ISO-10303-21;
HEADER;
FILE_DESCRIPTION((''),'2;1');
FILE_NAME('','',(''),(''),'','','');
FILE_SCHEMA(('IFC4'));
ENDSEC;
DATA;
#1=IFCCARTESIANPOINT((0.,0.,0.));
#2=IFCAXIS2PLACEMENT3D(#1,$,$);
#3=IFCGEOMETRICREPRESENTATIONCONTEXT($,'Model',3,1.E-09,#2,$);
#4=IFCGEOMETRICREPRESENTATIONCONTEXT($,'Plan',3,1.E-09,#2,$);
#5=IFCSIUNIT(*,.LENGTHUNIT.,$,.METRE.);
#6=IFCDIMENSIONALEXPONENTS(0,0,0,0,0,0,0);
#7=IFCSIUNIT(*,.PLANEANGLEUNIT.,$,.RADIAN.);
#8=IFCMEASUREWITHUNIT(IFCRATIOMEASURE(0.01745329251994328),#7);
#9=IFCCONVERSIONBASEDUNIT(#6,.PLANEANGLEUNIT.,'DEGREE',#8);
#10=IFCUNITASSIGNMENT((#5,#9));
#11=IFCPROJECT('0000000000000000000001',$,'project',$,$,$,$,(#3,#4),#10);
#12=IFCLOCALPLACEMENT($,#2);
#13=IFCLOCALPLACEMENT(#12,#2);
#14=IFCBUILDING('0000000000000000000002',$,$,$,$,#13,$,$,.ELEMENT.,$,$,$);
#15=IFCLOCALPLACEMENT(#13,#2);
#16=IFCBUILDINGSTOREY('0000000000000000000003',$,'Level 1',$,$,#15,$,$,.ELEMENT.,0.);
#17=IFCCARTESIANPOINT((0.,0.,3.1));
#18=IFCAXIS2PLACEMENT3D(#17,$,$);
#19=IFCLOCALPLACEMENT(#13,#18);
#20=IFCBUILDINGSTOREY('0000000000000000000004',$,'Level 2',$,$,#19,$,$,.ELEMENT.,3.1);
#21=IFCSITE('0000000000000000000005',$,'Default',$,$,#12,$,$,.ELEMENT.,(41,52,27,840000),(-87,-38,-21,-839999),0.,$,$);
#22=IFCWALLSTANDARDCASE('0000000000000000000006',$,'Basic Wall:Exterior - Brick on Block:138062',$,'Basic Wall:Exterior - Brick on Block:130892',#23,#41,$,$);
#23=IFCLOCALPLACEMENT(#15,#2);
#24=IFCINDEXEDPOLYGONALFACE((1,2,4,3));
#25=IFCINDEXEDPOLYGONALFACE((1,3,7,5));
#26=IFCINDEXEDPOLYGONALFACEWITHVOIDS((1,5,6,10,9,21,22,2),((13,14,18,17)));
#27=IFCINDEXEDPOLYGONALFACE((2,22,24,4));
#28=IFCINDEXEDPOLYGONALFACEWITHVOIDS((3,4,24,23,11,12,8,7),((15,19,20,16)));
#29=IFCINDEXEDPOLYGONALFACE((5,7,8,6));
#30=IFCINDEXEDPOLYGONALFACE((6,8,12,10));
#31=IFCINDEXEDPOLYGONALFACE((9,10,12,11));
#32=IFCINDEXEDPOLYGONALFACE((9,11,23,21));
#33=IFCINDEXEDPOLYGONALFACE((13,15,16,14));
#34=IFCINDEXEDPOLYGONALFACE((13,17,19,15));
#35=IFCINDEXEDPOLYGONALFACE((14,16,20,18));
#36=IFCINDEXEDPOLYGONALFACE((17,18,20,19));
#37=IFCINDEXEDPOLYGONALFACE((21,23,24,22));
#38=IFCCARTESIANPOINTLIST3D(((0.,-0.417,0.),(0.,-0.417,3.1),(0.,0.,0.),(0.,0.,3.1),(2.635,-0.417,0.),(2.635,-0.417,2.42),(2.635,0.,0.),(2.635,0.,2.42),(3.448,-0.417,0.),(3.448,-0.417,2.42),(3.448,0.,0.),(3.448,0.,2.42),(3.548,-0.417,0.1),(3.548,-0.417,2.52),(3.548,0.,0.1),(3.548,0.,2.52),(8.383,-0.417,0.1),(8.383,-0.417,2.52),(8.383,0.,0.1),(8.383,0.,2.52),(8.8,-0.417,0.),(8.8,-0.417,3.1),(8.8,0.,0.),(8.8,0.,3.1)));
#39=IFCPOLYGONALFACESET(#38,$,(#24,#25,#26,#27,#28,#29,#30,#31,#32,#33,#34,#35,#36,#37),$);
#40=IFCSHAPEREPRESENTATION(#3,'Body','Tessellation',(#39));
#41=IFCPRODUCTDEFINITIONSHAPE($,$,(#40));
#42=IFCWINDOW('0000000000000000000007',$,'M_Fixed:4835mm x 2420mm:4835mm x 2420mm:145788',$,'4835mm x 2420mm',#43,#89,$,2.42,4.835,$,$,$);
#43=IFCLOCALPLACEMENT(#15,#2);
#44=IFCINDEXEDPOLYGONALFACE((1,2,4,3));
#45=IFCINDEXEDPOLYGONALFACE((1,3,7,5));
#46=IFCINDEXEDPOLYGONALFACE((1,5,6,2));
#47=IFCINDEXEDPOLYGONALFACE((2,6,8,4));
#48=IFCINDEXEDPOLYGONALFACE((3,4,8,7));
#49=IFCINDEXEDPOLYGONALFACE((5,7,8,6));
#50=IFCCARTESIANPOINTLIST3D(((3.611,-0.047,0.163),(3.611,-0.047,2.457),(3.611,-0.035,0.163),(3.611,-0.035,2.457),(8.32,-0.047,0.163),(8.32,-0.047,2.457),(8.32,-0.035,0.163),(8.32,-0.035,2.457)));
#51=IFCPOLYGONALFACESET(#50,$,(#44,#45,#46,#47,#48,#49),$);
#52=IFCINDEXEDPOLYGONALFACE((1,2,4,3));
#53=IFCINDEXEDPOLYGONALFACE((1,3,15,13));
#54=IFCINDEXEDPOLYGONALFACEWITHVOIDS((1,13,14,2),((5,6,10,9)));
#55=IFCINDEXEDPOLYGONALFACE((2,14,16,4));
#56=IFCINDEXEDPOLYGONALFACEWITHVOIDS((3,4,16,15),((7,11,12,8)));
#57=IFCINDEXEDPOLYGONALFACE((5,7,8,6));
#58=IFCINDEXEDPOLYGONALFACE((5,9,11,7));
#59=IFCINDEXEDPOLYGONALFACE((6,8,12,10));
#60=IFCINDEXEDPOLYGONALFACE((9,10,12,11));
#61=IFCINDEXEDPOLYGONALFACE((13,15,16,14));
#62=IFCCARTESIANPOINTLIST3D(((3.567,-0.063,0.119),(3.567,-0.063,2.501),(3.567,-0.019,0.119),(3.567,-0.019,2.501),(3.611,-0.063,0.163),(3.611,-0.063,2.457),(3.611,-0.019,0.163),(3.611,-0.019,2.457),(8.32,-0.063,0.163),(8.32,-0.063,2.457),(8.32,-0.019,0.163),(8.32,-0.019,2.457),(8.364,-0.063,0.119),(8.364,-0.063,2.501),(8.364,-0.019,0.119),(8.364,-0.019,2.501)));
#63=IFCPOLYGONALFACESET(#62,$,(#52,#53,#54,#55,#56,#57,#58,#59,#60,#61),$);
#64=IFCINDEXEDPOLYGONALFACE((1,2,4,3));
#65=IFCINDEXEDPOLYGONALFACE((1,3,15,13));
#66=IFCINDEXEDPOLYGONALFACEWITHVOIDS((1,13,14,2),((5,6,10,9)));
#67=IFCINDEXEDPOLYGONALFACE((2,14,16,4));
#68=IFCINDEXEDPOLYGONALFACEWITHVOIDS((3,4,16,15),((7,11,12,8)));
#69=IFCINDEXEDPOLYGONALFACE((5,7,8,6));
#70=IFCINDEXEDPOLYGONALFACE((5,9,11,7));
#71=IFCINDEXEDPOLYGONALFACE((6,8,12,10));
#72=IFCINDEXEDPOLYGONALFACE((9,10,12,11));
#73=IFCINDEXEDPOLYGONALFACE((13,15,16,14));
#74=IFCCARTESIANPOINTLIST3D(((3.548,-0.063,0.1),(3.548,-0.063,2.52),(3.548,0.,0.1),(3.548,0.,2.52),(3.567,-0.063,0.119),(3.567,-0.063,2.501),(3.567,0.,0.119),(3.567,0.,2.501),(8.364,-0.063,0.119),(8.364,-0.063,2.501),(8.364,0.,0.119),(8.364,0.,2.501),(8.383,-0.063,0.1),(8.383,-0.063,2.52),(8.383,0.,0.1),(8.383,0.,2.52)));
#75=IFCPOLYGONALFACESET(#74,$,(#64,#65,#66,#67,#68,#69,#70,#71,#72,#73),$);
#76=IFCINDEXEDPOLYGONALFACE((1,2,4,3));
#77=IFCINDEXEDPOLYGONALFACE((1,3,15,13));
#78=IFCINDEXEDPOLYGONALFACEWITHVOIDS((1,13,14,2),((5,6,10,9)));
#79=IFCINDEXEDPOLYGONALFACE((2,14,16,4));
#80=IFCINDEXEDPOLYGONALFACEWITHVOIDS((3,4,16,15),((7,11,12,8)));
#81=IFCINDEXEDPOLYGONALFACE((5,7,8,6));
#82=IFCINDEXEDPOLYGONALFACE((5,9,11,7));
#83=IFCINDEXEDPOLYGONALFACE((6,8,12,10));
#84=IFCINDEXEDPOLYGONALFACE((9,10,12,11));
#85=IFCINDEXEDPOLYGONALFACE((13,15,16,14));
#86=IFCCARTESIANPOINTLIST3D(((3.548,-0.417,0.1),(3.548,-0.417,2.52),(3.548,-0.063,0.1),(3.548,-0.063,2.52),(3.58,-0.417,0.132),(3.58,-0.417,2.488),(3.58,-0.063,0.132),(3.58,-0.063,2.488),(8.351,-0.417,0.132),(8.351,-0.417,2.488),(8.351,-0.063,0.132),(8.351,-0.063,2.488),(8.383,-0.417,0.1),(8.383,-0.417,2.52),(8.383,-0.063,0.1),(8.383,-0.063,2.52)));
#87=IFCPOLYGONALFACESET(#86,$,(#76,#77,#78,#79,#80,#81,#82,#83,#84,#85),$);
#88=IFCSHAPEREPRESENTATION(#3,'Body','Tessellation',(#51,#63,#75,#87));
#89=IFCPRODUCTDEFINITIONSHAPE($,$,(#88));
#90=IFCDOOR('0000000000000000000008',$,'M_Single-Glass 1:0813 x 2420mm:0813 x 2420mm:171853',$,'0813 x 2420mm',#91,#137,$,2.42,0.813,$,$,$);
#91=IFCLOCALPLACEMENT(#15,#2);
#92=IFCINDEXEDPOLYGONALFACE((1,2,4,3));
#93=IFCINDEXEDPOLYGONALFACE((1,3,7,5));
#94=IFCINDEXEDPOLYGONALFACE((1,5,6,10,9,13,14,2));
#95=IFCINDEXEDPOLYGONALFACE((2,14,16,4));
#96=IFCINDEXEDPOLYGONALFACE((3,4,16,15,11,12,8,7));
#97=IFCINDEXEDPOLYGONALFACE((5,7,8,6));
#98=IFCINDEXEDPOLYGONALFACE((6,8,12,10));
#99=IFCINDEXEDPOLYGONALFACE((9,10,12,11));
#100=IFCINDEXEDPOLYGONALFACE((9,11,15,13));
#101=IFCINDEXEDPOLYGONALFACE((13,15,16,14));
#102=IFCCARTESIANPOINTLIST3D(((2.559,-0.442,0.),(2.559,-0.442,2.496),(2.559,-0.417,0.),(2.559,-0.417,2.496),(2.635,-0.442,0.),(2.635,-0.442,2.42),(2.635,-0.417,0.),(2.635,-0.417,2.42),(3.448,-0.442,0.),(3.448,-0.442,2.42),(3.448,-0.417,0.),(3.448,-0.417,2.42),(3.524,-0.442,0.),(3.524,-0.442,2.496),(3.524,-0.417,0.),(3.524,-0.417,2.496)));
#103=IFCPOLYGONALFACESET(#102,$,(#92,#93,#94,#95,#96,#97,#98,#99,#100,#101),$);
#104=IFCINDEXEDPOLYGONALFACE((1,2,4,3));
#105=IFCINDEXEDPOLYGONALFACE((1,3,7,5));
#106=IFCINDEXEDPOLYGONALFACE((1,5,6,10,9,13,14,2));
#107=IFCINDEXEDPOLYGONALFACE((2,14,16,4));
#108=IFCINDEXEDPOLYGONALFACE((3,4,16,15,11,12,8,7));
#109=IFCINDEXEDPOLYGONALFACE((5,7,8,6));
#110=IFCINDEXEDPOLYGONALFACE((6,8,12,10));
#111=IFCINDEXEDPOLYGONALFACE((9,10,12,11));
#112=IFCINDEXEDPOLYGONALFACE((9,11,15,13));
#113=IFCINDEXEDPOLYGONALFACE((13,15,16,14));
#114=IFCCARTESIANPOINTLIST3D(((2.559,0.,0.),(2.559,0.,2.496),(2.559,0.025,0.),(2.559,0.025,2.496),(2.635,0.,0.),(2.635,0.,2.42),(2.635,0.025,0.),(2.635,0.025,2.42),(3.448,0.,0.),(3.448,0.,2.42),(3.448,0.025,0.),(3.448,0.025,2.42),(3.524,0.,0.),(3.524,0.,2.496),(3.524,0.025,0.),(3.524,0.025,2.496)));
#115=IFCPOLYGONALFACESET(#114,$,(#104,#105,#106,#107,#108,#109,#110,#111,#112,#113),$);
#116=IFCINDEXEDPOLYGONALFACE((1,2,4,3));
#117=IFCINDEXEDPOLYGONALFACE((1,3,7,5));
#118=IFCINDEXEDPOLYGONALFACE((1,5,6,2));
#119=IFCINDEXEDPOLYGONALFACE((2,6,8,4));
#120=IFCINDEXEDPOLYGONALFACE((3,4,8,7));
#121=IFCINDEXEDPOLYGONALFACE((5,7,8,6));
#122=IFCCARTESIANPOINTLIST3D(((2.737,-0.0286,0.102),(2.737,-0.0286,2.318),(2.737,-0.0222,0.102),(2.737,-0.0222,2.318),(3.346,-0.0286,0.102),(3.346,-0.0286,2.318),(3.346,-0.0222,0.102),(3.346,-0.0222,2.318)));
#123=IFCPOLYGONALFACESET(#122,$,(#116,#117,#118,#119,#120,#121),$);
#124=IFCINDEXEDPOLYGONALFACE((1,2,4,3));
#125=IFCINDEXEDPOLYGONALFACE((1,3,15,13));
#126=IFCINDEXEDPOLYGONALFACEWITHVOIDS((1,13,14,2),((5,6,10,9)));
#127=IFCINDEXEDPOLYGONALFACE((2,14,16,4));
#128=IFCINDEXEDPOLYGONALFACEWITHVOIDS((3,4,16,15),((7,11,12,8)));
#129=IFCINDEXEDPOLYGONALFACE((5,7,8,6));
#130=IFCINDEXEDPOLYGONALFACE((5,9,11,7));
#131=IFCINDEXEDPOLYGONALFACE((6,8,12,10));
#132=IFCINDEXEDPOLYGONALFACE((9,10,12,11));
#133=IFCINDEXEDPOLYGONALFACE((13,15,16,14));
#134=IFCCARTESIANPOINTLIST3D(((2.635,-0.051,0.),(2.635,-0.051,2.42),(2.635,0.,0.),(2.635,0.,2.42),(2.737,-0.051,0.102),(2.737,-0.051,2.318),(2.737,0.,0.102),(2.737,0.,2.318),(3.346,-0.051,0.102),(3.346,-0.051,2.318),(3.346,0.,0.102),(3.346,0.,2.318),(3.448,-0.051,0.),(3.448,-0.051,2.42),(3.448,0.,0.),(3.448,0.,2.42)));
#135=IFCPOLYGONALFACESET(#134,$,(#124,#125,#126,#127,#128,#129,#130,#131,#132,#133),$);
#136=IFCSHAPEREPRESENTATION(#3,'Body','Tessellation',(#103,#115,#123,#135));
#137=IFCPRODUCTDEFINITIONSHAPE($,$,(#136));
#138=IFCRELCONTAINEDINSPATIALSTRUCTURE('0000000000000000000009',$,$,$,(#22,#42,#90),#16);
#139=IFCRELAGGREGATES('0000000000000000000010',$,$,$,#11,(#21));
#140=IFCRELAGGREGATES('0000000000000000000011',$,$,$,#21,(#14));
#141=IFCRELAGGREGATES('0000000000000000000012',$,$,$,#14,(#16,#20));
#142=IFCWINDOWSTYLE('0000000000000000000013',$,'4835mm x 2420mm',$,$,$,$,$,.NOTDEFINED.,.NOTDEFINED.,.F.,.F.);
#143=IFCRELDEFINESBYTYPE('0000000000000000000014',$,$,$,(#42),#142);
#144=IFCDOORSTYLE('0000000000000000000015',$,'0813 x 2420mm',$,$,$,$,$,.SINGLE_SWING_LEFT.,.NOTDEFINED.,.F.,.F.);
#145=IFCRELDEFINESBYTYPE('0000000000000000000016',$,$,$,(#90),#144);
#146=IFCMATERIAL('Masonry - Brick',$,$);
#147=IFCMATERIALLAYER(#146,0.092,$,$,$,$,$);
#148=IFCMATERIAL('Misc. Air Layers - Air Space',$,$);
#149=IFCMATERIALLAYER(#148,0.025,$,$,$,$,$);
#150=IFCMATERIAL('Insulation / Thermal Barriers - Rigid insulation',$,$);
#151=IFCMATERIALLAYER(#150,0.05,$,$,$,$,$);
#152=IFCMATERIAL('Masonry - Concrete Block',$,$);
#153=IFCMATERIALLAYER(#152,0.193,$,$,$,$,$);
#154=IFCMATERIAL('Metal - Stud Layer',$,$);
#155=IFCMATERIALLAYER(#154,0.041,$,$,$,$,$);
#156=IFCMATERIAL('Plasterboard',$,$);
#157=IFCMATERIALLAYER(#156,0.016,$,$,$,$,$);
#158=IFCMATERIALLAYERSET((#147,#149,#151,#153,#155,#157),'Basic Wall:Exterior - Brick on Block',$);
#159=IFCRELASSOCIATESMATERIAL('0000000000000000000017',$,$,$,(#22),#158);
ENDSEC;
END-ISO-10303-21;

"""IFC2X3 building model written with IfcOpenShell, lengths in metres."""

from ifc_helpers import new_model, entity, si_unit, converted_unit, frame, frame_2d, origin, origin_2d_with_axis, place, context, project, spatial, polyline, rectangle, outline, extrude, source, transform, mapped, material, layer, layer_set, layer_usage, type_object, type_shapes, element, fill, save


model = new_model("IFC2X3")

# Units and contexts
model_context = context("Model", 3, precision=1e-09, world=origin())
plan_context = context("Plan", 3, precision=1e-09, world=origin())
ifc_project = project(units=[si_unit("LENGTHUNIT", "METRE"), converted_unit("PLANEANGLEUNIT", "DEGREE", entity("IfcRatioMeasure", 0.01745329251994328), si_unit("PLANEANGLEUNIT", "RADIAN"), dimensions=[0, 0, 0, 0, 0, 0, 0])], contexts=[model_context, plan_context])

# Site, building, storey
site_placement = place(None, origin())
site = spatial("IfcSite", under=ifc_project, at=site_placement, Name="Default", CompositionType="ELEMENT", RefLatitude=(41, 52, 27, 840000), RefLongitude=(-87, -38, -21, -839999), RefElevation=0.0)
building_placement = place(site_placement, origin())
building = spatial("IfcBuilding", under=site, at=building_placement, CompositionType="ELEMENT")
storey_1_placement = place(building_placement, origin())
storey_1 = spatial("IfcBuildingStorey", under=building, at=storey_1_placement, Name="Level 1", CompositionType="ELEMENT", Elevation=0.0)

# Shared definitions
ifc_material_1 = material(Name="Masonry - Brick")
ifc_layer_1 = layer(ifc_material_1, 0.092)
ifc_material_2 = material(Name="Misc. Air Layers - Air Space")
ifc_layer_2 = layer(ifc_material_2, 0.025)
ifc_material_3 = material(Name="Insulation / Thermal Barriers - Rigid insulation")
ifc_layer_3 = layer(ifc_material_3, 0.05)
ifc_material_4 = material(Name="Masonry - Concrete Block")
ifc_layer_4 = layer(ifc_material_4, 0.193)
ifc_material_5 = material(Name="Metal - Stud Layer")
ifc_layer_5 = layer(ifc_material_5, 0.041)
ifc_material_6 = material(Name="Plasterboard")
ifc_layer_6 = layer(ifc_material_6, 0.016)
ifc_layer_set_1 = layer_set([ifc_layer_1, ifc_layer_2, ifc_layer_3, ifc_layer_4, ifc_layer_5, ifc_layer_6], Name="Basic Wall:Exterior - Brick on Block")
ifc_layer_usage_1 = layer_usage(ifc_layer_set_1, "AXIS2", "NEGATIVE", 0.2085)

# Wall, openings, window, door
wall_1_placement = place(storey_1_placement, frame((0.0, -0.2085, 0.0)))
wall_1 = element("IfcWallStandardCase", 1, at=wall_1_placement, inside=storey_1, material=ifc_layer_usage_1, Name="Basic Wall:Exterior - Brick on Block:138062", ObjectType="Basic Wall:Exterior - Brick on Block:130892", context=model_context, shape_type="SweptSolid", body=[
    extrude(rectangle(XDim=8.8, YDim=0.417, at=frame_2d((4.4, 0.0), x_axis=(-1.0, 0.0))), origin(), (0.0, 0.0, 1.0), 3.1),
])
opening_1_placement = place(wall_1_placement, frame((3.548, -0.2085, 0.1)))
opening_1 = element("IfcOpeningElement", 2, at=opening_1_placement, cuts=wall_1, ObjectType="Opening", context=model_context, shape_type="SweptSolid", body=[
    extrude(rectangle(XDim=2.42, YDim=4.835, at=frame_2d((1.21, 2.4175), x_axis=(1.0, 0.0))), frame((0.0, 0.0, 0.0), z_axis=(0.0, 1.0, 0.0), x_axis=(0.0, 0.0, 1.0)), (0.0, 0.0, 1.0), 0.417),
])
opening_2_placement = place(wall_1_placement, frame((2.635, -0.2085, 0.0)))
opening_2 = element("IfcOpeningElement", 3, at=opening_2_placement, cuts=wall_1, ObjectType="Opening", context=model_context, shape_type="SweptSolid", body=[
    extrude(rectangle(XDim=0.813, YDim=2.42, at=frame_2d((1.21, 0.4065), x_axis=(0.0, -1.0))), frame((0.0, 0.0, 0.0), z_axis=(0.0, 1.0, 0.0), x_axis=(0.0, 0.0, 1.0)), (0.0, 0.0, 1.0), 0.417),
])
window_style_1 = type_object("IfcWindowStyle", Name="4835mm x 2420mm", ConstructionType="NOTDEFINED", OperationType="NOTDEFINED", ParameterTakesPrecedence=False, Sizeable=False)
shared_shape_1 = source(origin(), model_context, "Body", "SweptSolid", [
    extrude(rectangle(XDim=0.012, YDim=4.709, at=origin_2d_with_axis()), frame((2.4175, 0.376, 0.063), z_axis=(0.0, 0.0, 1.0), x_axis=(0.0, -1.0, 0.0)), (0.0, 0.0, 1.0), 2.294),
    extrude(outline(polyline([(-2.3985, -1.191), (2.3985, -1.191), (2.3985, 1.191), (-2.3985, 1.191), (-2.3985, -1.191)]), holes=[polyline([(-2.3545, -1.147), (-2.3545, 1.147), (2.3545, 1.147), (2.3545, -1.147), (-2.3545, -1.147)])]), frame((2.4175, 0.354, 1.21), z_axis=(0.0, 1.0, 0.0), x_axis=(1.0, 0.0, 0.0)), (0.0, 0.0, 1.0), 0.044),
    extrude(outline(polyline([(-2.4175, -1.21), (2.4175, -1.21), (2.4175, 1.21), (-2.4175, 1.21), (-2.4175, -1.21)]), holes=[polyline([(-2.3985, -1.191), (-2.3985, 1.191), (2.3985, 1.191), (2.3985, -1.191), (-2.3985, -1.191)])]), frame((2.4175, 0.354, 1.21), z_axis=(0.0, 1.0, 0.0), x_axis=(1.0, 0.0, 0.0)), (0.0, 0.0, 1.0), 0.063),
    extrude(outline(polyline([(-2.4175, -1.21), (2.4175, -1.21), (2.4175, 1.21), (-2.4175, 1.21), (-2.4175, -1.21)]), holes=[polyline([(-2.3855, -1.178), (-2.3855, 1.178), (2.3855, 1.178), (2.3855, -1.178), (-2.3855, -1.178)])]), frame((2.4175, 0.0, 1.21), z_axis=(0.0, 1.0, 0.0), x_axis=(1.0, 0.0, 0.0)), (0.0, 0.0, 1.0), 0.354),
])
type_shapes(window_style_1, [shared_shape_1])
window_1_placement = place(opening_1_placement, origin())
window_1 = element("IfcWindow", 4, at=window_1_placement, inside=storey_1, type_object=window_style_1, Name="M_Fixed:4835mm x 2420mm:4835mm x 2420mm:145788", ObjectType="4835mm x 2420mm", OverallHeight=2.42, OverallWidth=4.835, context=model_context, shape_type="MappedRepresentation", body=[
    mapped(shared_shape_1, transform((0.0, 0.0, 0.0), scale=1.0)),
])
fill(opening_1, window_1)
door_style_1 = type_object("IfcDoorStyle", Name="0813 x 2420mm", ConstructionType="NOTDEFINED", OperationType="SINGLE_SWING_LEFT", ParameterTakesPrecedence=False, Sizeable=False)
shared_shape_2 = source(origin(), model_context, "Body", "SweptSolid", [
    extrude(outline(polyline([(-0.4065, -1.191), (-0.4065, 1.229), (-0.4825, 1.229), (-0.4825, -1.267), (0.4825, -1.267), (0.4825, 1.229), (0.4065, 1.229), (0.4065, -1.191), (-0.4065, -1.191)])), frame((0.4065, 0.0, 1.229), z_axis=(0.0, 1.0, 0.0), x_axis=(1.0, 0.0, 0.0)), (0.0, 0.0, -1.0), 0.025),
    extrude(outline(polyline([(-0.4065, -1.191), (-0.4065, 1.229), (-0.4825, 1.229), (-0.4825, -1.267), (0.4825, -1.267), (0.4825, 1.229), (0.4065, 1.229), (0.4065, -1.191), (-0.4065, -1.191)])), frame((0.4065, 0.442, 1.229), z_axis=(0.0, 1.0, 0.0), x_axis=(1.0, 0.0, 0.0)), (0.0, 0.0, -1.0), 0.025),
    extrude(rectangle(XDim=0.609, YDim=0.0064, at=origin_2d_with_axis()), frame((0.4065, 0.3916, 0.102)), (0.0, 0.0, 1.0), 2.216),
    extrude(outline(polyline([(-1.21, -0.4065), (1.21, -0.4065), (1.21, 0.4065), (-1.21, 0.4065), (-1.21, -0.4065)]), holes=[polyline([(-1.108, 0.3045), (1.108, 0.3045), (1.108, -0.3045), (-1.108, -0.3045), (-1.108, 0.3045)])]), frame((0.4065, 0.417, 1.21), z_axis=(0.0, -1.0, 0.0), x_axis=(0.0, 0.0, -1.0)), (0.0, 0.0, 1.0), 0.051),
])
type_shapes(door_style_1, [shared_shape_2])
door_1_placement = place(opening_2_placement, origin())
door_1 = element("IfcDoor", 5, at=door_1_placement, inside=storey_1, type_object=door_style_1, Name="M_Single-Glass 1:0813 x 2420mm:0813 x 2420mm:171853", ObjectType="0813 x 2420mm", OverallHeight=2.42, OverallWidth=0.813, context=model_context, shape_type="MappedRepresentation", body=[
    mapped(shared_shape_2, transform((0.0, 0.0, 0.0), scale=1.0)),
])
fill(opening_2, door_1)

# Shared definitions
storey_2_placement = place(building_placement, frame((0.0, 0.0, 3.1)))
storey_2 = spatial("IfcBuildingStorey", under=building, at=storey_2_placement, Name="Level 2", CompositionType="ELEMENT", Elevation=3.1)

save(model, "model.ifc")
